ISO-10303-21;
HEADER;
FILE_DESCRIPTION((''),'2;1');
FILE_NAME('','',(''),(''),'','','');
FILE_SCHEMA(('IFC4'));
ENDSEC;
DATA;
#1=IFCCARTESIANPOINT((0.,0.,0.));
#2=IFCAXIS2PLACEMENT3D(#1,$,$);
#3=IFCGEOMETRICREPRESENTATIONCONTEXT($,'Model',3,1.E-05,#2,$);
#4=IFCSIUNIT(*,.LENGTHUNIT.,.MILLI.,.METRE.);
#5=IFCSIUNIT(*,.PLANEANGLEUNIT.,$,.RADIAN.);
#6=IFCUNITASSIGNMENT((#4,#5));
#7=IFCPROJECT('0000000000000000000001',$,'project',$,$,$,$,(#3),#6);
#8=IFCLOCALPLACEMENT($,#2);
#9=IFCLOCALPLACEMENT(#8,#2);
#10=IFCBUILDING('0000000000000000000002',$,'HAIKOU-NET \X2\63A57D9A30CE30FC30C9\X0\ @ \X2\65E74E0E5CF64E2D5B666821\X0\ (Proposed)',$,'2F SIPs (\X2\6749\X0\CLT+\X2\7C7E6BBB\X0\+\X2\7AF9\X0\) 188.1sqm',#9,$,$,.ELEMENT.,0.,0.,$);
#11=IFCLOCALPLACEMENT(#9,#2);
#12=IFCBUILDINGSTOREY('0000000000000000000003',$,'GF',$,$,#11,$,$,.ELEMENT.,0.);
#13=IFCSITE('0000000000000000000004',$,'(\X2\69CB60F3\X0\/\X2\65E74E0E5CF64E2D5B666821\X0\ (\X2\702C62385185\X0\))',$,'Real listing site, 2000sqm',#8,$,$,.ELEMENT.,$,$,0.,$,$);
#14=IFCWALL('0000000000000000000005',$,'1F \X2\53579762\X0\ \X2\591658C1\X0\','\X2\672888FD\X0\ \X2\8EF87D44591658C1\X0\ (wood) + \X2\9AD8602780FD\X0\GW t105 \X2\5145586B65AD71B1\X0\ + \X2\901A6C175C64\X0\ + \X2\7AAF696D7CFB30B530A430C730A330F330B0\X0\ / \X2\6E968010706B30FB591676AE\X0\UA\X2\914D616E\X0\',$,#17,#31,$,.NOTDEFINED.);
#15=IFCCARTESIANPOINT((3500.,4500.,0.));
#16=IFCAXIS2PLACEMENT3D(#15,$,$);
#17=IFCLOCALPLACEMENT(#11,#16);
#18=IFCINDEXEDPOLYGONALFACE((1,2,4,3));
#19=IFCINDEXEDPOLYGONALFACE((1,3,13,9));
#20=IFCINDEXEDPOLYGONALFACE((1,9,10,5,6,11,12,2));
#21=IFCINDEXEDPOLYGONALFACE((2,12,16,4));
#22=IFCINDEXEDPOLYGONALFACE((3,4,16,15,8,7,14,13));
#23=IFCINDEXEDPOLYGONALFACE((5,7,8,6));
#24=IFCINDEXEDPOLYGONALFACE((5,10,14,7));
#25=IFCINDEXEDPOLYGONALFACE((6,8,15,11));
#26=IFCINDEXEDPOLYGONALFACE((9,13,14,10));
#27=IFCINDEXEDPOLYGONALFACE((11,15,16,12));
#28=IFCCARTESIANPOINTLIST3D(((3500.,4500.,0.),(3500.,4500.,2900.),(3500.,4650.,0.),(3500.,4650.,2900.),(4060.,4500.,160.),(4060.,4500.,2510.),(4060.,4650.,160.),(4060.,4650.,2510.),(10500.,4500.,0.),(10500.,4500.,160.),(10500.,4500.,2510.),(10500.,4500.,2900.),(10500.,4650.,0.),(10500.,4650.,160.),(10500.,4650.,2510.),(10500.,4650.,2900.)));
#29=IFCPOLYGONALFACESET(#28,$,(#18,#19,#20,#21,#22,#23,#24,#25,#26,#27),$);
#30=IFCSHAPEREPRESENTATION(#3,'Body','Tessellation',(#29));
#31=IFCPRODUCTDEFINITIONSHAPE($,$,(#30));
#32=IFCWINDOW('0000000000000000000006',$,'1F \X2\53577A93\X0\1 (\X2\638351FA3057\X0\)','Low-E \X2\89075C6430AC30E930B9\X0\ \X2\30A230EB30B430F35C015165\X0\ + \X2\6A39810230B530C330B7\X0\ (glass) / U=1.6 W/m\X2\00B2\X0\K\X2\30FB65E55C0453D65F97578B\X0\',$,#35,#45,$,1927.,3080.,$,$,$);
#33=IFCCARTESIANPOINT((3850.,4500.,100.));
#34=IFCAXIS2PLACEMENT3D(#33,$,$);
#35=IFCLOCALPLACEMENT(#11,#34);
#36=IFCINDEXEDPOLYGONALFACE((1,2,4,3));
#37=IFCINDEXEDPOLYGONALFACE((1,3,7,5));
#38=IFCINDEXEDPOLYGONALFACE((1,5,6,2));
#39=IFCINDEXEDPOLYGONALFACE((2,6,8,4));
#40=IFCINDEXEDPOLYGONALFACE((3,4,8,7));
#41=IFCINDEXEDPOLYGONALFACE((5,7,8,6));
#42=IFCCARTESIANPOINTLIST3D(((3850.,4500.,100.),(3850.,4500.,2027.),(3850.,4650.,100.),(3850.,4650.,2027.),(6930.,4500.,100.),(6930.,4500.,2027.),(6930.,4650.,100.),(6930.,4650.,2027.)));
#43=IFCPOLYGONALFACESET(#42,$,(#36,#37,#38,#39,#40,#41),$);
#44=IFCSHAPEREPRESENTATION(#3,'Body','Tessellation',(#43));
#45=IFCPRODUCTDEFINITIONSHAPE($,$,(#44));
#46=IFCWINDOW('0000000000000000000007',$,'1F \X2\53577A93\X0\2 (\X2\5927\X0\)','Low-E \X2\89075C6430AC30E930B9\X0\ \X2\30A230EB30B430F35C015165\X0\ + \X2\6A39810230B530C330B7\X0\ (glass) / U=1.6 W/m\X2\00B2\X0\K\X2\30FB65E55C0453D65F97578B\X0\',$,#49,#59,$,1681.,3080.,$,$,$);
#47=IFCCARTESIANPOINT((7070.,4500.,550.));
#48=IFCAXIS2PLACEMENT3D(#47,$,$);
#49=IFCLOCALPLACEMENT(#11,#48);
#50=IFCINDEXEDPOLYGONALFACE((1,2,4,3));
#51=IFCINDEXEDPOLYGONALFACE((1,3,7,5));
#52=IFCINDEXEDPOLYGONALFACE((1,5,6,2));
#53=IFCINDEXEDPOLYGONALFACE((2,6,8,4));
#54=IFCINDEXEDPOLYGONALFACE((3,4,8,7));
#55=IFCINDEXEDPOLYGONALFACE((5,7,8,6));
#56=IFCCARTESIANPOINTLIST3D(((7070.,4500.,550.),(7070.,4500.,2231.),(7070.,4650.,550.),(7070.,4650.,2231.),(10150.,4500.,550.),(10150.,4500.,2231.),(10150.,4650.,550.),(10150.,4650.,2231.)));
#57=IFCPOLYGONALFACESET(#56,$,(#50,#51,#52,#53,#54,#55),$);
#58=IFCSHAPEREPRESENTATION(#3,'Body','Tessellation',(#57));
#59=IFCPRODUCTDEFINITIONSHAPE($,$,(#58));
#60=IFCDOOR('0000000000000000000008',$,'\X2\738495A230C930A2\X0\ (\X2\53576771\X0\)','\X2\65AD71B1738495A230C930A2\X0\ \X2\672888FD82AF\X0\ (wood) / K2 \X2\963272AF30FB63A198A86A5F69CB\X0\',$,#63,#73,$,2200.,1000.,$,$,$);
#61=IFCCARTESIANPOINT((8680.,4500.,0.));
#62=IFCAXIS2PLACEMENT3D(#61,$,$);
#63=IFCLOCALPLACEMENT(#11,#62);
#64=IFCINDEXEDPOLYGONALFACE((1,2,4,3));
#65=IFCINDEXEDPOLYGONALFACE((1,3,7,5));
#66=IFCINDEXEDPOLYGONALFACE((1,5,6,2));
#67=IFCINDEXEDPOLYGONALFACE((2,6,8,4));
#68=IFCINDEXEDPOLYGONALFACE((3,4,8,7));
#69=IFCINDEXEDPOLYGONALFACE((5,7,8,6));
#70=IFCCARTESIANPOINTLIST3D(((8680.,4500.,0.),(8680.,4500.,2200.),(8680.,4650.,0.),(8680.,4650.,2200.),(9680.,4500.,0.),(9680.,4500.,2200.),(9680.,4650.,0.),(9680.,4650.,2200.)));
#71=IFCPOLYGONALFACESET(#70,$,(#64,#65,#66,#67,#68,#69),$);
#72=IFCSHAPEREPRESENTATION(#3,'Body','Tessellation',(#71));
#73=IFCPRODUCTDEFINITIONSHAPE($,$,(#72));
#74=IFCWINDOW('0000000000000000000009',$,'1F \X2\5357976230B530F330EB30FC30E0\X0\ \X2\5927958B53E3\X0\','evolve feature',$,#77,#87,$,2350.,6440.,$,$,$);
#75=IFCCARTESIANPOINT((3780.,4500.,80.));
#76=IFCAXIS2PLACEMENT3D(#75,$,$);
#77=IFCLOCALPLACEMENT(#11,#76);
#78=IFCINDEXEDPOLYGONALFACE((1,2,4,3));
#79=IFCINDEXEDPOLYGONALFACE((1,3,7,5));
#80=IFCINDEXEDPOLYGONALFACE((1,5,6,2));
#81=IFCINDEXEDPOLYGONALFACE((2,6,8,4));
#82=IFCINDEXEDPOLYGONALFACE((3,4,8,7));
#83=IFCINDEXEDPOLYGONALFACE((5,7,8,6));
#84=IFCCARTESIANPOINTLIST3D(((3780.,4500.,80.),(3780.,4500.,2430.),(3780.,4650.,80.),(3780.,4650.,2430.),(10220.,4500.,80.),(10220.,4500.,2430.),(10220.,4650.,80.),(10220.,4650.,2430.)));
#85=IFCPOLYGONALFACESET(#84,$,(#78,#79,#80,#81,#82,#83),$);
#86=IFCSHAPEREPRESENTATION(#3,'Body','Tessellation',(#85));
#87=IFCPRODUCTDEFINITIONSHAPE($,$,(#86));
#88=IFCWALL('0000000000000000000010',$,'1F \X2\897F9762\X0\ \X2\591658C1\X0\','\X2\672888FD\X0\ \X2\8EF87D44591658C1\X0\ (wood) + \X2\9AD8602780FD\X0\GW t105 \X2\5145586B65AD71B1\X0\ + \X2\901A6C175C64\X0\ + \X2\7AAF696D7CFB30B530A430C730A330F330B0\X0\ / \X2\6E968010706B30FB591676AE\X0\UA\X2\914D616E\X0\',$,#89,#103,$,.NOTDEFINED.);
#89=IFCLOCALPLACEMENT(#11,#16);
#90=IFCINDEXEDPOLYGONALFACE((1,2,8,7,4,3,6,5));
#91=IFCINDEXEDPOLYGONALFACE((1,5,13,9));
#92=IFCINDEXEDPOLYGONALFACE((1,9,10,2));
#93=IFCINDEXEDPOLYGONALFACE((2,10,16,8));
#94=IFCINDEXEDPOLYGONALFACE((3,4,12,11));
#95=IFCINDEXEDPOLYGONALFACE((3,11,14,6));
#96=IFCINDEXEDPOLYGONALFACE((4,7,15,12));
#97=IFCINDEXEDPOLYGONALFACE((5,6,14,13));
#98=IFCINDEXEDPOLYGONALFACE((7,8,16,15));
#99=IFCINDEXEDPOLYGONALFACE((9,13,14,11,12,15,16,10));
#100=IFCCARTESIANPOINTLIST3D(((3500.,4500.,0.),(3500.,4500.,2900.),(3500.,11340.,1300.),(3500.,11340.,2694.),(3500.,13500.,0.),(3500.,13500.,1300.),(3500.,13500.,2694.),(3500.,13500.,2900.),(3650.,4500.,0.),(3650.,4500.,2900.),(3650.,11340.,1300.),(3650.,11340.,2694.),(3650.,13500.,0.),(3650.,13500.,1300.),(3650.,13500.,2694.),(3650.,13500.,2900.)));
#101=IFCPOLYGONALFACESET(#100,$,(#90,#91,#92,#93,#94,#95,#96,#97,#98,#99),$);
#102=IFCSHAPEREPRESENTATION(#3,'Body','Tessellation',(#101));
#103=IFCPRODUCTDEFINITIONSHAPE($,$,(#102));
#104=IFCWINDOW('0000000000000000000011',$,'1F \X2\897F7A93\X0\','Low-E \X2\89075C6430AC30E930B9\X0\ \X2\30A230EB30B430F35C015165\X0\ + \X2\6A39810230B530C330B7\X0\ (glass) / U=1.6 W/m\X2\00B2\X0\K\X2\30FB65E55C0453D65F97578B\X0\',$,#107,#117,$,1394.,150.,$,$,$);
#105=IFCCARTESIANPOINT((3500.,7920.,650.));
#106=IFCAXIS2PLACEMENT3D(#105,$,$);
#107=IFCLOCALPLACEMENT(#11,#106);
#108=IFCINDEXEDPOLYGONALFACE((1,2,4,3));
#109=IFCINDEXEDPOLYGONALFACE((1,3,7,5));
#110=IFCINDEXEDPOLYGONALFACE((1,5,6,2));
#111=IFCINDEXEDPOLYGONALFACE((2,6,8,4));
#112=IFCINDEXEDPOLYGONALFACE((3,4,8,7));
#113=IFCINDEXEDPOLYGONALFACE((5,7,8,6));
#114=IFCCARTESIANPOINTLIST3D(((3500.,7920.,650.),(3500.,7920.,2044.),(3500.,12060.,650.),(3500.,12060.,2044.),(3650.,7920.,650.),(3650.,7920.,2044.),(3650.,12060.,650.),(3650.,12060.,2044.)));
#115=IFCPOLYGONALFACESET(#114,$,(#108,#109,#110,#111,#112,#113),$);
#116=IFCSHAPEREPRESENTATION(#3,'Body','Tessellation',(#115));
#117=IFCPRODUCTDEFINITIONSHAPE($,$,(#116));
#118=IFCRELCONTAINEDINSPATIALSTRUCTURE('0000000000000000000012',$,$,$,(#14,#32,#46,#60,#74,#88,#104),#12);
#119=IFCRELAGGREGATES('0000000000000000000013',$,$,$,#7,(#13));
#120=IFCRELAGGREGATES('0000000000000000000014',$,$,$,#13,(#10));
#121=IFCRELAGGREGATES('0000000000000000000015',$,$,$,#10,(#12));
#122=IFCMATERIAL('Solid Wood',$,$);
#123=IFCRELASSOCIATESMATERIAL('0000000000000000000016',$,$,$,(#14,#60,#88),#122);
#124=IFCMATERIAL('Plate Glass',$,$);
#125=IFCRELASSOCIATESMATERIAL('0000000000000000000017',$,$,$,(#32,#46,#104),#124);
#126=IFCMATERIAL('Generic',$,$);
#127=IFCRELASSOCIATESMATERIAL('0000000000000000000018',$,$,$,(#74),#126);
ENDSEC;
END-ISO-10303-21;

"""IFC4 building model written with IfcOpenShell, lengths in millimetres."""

from ifc_helpers import new_model, si_unit, frame, frame_2d, origin, place, context, project, spatial, rectangle, extrude, material, element, fill, save


model = new_model("IFC4")

# Units and contexts
model_context = context("Model", 3, precision=1e-05, world=origin())
ifc_project = project(units=[si_unit("LENGTHUNIT", "METRE", prefix="MILLI"), si_unit("PLANEANGLEUNIT", "RADIAN")], contexts=[model_context])

# Site, building, storey
site_placement = place(None, origin())
site = spatial("IfcSite", under=ifc_project, at=site_placement, Name="(構想/旧与島中学校 (瀬戸内))", ObjectType="Real listing site, 2000sqm", CompositionType="ELEMENT", RefElevation=0.0)
building_placement = place(site_placement, origin())
building = spatial("IfcBuilding", under=site, at=building_placement, Name="HAIKOU-NET 接続ノード @ 旧与島中学校 (Proposed)", ObjectType="2F SIPs (杉CLT+籾殻+竹) 188.1sqm", CompositionType="ELEMENT", ElevationOfRefHeight=0.0, ElevationOfTerrain=0.0)
storey_placement = place(building_placement, origin())
storey = spatial("IfcBuildingStorey", under=building, at=storey_placement, Name="GF", CompositionType="ELEMENT", Elevation=0.0)

# Shared definitions
ifc_material_1 = material(Name="Solid Wood")

# Wall, openings, windows, door
wall_1_placement = place(storey_placement, frame((3500.0, 4500.0, 0.0)))
wall_1 = element("IfcWall", 1, at=wall_1_placement, inside=storey, material=ifc_material_1, Name="1F 南面 外壁", Description="木製 軸組外壁 (wood) + 高性能GW t105 充填断熱 + 通気層 + 窯業系サイディング / 準耐火・外皮UA配慮", PredefinedType="NOTDEFINED", context=model_context, shape_type="SweptSolid", body=[
    extrude(rectangle(XDim=7000.0, YDim=150.0, at=frame_2d((3500.0, 75.0))), frame((3500.0, 4500.0, 0.0)), (0.0, 0.0, 1.0), 2900.0),
])
opening_1_placement = place(storey_placement, frame((3850.0, 4500.0, 100.0)))
opening_1 = element("IfcOpeningElement", 2, at=opening_1_placement, cuts=wall_1, PredefinedType="NOTDEFINED", context=model_context, shape_type="SweptSolid", body=[
    extrude(rectangle(XDim=3080.0, YDim=150.0, at=frame_2d((1540.0, 75.0))), frame((3850.0, 4500.0, 100.0)), (0.0, 0.0, 1.0), 1927.0),
])
opening_2_placement = place(storey_placement, frame((7070.0, 4500.0, 550.0)))
opening_2 = element("IfcOpeningElement", 3, at=opening_2_placement, cuts=wall_1, PredefinedType="NOTDEFINED", context=model_context, shape_type="SweptSolid", body=[
    extrude(rectangle(XDim=3080.0, YDim=150.0, at=frame_2d((1540.0, 75.0))), frame((7070.0, 4500.0, 550.0)), (0.0, 0.0, 1.0), 1681.0),
])
opening_3_placement = place(storey_placement, frame((8680.0, 4500.0, 0.0)))
opening_3 = element("IfcOpeningElement", 4, at=opening_3_placement, cuts=wall_1, PredefinedType="NOTDEFINED", context=model_context, shape_type="SweptSolid", body=[
    extrude(rectangle(XDim=1000.0, YDim=150.0, at=frame_2d((500.0, 75.0))), frame((8680.0, 4500.0, 0.0)), (0.0, 0.0, 1.0), 2200.0),
])
opening_4_placement = place(storey_placement, frame((3780.0, 4500.0, 80.0)))
opening_4 = element("IfcOpeningElement", 5, at=opening_4_placement, cuts=wall_1, PredefinedType="NOTDEFINED", context=model_context, shape_type="SweptSolid", body=[
    extrude(rectangle(XDim=6440.0, YDim=150.0, at=frame_2d((3220.0, 75.0))), frame((3780.0, 4500.0, 80.0)), (0.0, 0.0, 1.0), 2350.0),
])
ifc_material_2 = material(Name="Plate Glass")
window_1_placement = place(storey_placement, frame((3850.0, 4500.0, 100.0)))
window_1 = element("IfcWindow", 6, at=window_1_placement, inside=storey, material=ifc_material_2, Name="1F 南窓1 (掃出し)", Description="Low-E 複層ガラス アルゴン封入 + 樹脂サッシ (glass) / U=1.6 W/m²K・日射取得型", OverallHeight=1927.0, OverallWidth=3080.0, context=model_context, shape_type="SweptSolid", body=[
    extrude(rectangle(XDim=3080.0, YDim=150.0, at=frame_2d((1540.0, 75.0))), frame((3850.0, 4500.0, 100.0)), (0.0, 0.0, 1.0), 1927.0),
])
fill(opening_1, window_1)
window_2_placement = place(storey_placement, frame((7070.0, 4500.0, 550.0)))
window_2 = element("IfcWindow", 7, at=window_2_placement, inside=storey, material=ifc_material_2, Name="1F 南窓2 (大)", Description="Low-E 複層ガラス アルゴン封入 + 樹脂サッシ (glass) / U=1.6 W/m²K・日射取得型", OverallHeight=1681.0, OverallWidth=3080.0, context=model_context, shape_type="SweptSolid", body=[
    extrude(rectangle(XDim=3080.0, YDim=150.0, at=frame_2d((1540.0, 75.0))), frame((7070.0, 4500.0, 550.0)), (0.0, 0.0, 1.0), 1681.0),
])
fill(opening_2, window_2)
door_placement = place(storey_placement, frame((8680.0, 4500.0, 0.0)))
door = element("IfcDoor", 8, at=door_placement, inside=storey, material=ifc_material_1, Name="玄関ドア (南東)", Description="断熱玄関ドア 木製芯 (wood) / K2 防犯・採風機構", OverallHeight=2200.0, OverallWidth=1000.0, context=model_context, shape_type="SweptSolid", body=[
    extrude(rectangle(XDim=1000.0, YDim=150.0, at=frame_2d((500.0, 75.0))), frame((8680.0, 4500.0, 0.0)), (0.0, 0.0, 1.0), 2200.0),
])
fill(opening_3, door)
ifc_material_3 = material(Name="Generic")
window_3_placement = place(storey_placement, frame((3780.0, 4500.0, 80.0)))
window_3 = element("IfcWindow", 9, at=window_3_placement, inside=storey, material=ifc_material_3, Name="1F 南面サンルーム 大開口", Description="evolve feature", OverallHeight=2350.0, OverallWidth=6440.0, context=model_context, shape_type="SweptSolid", body=[
    extrude(rectangle(XDim=6440.0, YDim=150.0, at=frame_2d((3220.0, 75.0))), frame((3780.0, 4500.0, 80.0)), (0.0, 0.0, 1.0), 2350.0),
])
fill(opening_4, window_3)

# Wall, opening, window
wall_2_placement = place(storey_placement, frame((3500.0, 4500.0, 0.0)))
wall_2 = element("IfcWall", 10, at=wall_2_placement, inside=storey, material=ifc_material_1, Name="1F 西面 外壁", Description="木製 軸組外壁 (wood) + 高性能GW t105 充填断熱 + 通気層 + 窯業系サイディング / 準耐火・外皮UA配慮", PredefinedType="NOTDEFINED", context=model_context, shape_type="SweptSolid", body=[
    extrude(rectangle(XDim=150.0, YDim=9000.0, at=frame_2d((75.0, 4500.0))), frame((3500.0, 4500.0, 0.0)), (0.0, 0.0, 1.0), 2900.0),
])
opening_5_placement = place(storey_placement, frame((3500.0, 7920.0, 650.0)))
opening_5 = element("IfcOpeningElement", 11, at=opening_5_placement, cuts=wall_2, PredefinedType="NOTDEFINED", context=model_context, shape_type="SweptSolid", body=[
    extrude(rectangle(XDim=150.0, YDim=4140.0, at=frame_2d((75.0, 2070.0))), frame((3500.0, 7920.0, 650.0)), (0.0, 0.0, 1.0), 1394.0),
])
window_4_placement = place(storey_placement, frame((3500.0, 7920.0, 650.0)))
window_4 = element("IfcWindow", 12, at=window_4_placement, inside=storey, material=ifc_material_2, Name="1F 西窓", Description="Low-E 複層ガラス アルゴン封入 + 樹脂サッシ (glass) / U=1.6 W/m²K・日射取得型", OverallHeight=1394.0, OverallWidth=150.0, context=model_context, shape_type="SweptSolid", body=[
    extrude(rectangle(XDim=150.0, YDim=4140.0, at=frame_2d((75.0, 2070.0))), frame((3500.0, 7920.0, 650.0)), (0.0, 0.0, 1.0), 1394.0),
])
fill(opening_5, window_4)

save(model, "model.ifc")
